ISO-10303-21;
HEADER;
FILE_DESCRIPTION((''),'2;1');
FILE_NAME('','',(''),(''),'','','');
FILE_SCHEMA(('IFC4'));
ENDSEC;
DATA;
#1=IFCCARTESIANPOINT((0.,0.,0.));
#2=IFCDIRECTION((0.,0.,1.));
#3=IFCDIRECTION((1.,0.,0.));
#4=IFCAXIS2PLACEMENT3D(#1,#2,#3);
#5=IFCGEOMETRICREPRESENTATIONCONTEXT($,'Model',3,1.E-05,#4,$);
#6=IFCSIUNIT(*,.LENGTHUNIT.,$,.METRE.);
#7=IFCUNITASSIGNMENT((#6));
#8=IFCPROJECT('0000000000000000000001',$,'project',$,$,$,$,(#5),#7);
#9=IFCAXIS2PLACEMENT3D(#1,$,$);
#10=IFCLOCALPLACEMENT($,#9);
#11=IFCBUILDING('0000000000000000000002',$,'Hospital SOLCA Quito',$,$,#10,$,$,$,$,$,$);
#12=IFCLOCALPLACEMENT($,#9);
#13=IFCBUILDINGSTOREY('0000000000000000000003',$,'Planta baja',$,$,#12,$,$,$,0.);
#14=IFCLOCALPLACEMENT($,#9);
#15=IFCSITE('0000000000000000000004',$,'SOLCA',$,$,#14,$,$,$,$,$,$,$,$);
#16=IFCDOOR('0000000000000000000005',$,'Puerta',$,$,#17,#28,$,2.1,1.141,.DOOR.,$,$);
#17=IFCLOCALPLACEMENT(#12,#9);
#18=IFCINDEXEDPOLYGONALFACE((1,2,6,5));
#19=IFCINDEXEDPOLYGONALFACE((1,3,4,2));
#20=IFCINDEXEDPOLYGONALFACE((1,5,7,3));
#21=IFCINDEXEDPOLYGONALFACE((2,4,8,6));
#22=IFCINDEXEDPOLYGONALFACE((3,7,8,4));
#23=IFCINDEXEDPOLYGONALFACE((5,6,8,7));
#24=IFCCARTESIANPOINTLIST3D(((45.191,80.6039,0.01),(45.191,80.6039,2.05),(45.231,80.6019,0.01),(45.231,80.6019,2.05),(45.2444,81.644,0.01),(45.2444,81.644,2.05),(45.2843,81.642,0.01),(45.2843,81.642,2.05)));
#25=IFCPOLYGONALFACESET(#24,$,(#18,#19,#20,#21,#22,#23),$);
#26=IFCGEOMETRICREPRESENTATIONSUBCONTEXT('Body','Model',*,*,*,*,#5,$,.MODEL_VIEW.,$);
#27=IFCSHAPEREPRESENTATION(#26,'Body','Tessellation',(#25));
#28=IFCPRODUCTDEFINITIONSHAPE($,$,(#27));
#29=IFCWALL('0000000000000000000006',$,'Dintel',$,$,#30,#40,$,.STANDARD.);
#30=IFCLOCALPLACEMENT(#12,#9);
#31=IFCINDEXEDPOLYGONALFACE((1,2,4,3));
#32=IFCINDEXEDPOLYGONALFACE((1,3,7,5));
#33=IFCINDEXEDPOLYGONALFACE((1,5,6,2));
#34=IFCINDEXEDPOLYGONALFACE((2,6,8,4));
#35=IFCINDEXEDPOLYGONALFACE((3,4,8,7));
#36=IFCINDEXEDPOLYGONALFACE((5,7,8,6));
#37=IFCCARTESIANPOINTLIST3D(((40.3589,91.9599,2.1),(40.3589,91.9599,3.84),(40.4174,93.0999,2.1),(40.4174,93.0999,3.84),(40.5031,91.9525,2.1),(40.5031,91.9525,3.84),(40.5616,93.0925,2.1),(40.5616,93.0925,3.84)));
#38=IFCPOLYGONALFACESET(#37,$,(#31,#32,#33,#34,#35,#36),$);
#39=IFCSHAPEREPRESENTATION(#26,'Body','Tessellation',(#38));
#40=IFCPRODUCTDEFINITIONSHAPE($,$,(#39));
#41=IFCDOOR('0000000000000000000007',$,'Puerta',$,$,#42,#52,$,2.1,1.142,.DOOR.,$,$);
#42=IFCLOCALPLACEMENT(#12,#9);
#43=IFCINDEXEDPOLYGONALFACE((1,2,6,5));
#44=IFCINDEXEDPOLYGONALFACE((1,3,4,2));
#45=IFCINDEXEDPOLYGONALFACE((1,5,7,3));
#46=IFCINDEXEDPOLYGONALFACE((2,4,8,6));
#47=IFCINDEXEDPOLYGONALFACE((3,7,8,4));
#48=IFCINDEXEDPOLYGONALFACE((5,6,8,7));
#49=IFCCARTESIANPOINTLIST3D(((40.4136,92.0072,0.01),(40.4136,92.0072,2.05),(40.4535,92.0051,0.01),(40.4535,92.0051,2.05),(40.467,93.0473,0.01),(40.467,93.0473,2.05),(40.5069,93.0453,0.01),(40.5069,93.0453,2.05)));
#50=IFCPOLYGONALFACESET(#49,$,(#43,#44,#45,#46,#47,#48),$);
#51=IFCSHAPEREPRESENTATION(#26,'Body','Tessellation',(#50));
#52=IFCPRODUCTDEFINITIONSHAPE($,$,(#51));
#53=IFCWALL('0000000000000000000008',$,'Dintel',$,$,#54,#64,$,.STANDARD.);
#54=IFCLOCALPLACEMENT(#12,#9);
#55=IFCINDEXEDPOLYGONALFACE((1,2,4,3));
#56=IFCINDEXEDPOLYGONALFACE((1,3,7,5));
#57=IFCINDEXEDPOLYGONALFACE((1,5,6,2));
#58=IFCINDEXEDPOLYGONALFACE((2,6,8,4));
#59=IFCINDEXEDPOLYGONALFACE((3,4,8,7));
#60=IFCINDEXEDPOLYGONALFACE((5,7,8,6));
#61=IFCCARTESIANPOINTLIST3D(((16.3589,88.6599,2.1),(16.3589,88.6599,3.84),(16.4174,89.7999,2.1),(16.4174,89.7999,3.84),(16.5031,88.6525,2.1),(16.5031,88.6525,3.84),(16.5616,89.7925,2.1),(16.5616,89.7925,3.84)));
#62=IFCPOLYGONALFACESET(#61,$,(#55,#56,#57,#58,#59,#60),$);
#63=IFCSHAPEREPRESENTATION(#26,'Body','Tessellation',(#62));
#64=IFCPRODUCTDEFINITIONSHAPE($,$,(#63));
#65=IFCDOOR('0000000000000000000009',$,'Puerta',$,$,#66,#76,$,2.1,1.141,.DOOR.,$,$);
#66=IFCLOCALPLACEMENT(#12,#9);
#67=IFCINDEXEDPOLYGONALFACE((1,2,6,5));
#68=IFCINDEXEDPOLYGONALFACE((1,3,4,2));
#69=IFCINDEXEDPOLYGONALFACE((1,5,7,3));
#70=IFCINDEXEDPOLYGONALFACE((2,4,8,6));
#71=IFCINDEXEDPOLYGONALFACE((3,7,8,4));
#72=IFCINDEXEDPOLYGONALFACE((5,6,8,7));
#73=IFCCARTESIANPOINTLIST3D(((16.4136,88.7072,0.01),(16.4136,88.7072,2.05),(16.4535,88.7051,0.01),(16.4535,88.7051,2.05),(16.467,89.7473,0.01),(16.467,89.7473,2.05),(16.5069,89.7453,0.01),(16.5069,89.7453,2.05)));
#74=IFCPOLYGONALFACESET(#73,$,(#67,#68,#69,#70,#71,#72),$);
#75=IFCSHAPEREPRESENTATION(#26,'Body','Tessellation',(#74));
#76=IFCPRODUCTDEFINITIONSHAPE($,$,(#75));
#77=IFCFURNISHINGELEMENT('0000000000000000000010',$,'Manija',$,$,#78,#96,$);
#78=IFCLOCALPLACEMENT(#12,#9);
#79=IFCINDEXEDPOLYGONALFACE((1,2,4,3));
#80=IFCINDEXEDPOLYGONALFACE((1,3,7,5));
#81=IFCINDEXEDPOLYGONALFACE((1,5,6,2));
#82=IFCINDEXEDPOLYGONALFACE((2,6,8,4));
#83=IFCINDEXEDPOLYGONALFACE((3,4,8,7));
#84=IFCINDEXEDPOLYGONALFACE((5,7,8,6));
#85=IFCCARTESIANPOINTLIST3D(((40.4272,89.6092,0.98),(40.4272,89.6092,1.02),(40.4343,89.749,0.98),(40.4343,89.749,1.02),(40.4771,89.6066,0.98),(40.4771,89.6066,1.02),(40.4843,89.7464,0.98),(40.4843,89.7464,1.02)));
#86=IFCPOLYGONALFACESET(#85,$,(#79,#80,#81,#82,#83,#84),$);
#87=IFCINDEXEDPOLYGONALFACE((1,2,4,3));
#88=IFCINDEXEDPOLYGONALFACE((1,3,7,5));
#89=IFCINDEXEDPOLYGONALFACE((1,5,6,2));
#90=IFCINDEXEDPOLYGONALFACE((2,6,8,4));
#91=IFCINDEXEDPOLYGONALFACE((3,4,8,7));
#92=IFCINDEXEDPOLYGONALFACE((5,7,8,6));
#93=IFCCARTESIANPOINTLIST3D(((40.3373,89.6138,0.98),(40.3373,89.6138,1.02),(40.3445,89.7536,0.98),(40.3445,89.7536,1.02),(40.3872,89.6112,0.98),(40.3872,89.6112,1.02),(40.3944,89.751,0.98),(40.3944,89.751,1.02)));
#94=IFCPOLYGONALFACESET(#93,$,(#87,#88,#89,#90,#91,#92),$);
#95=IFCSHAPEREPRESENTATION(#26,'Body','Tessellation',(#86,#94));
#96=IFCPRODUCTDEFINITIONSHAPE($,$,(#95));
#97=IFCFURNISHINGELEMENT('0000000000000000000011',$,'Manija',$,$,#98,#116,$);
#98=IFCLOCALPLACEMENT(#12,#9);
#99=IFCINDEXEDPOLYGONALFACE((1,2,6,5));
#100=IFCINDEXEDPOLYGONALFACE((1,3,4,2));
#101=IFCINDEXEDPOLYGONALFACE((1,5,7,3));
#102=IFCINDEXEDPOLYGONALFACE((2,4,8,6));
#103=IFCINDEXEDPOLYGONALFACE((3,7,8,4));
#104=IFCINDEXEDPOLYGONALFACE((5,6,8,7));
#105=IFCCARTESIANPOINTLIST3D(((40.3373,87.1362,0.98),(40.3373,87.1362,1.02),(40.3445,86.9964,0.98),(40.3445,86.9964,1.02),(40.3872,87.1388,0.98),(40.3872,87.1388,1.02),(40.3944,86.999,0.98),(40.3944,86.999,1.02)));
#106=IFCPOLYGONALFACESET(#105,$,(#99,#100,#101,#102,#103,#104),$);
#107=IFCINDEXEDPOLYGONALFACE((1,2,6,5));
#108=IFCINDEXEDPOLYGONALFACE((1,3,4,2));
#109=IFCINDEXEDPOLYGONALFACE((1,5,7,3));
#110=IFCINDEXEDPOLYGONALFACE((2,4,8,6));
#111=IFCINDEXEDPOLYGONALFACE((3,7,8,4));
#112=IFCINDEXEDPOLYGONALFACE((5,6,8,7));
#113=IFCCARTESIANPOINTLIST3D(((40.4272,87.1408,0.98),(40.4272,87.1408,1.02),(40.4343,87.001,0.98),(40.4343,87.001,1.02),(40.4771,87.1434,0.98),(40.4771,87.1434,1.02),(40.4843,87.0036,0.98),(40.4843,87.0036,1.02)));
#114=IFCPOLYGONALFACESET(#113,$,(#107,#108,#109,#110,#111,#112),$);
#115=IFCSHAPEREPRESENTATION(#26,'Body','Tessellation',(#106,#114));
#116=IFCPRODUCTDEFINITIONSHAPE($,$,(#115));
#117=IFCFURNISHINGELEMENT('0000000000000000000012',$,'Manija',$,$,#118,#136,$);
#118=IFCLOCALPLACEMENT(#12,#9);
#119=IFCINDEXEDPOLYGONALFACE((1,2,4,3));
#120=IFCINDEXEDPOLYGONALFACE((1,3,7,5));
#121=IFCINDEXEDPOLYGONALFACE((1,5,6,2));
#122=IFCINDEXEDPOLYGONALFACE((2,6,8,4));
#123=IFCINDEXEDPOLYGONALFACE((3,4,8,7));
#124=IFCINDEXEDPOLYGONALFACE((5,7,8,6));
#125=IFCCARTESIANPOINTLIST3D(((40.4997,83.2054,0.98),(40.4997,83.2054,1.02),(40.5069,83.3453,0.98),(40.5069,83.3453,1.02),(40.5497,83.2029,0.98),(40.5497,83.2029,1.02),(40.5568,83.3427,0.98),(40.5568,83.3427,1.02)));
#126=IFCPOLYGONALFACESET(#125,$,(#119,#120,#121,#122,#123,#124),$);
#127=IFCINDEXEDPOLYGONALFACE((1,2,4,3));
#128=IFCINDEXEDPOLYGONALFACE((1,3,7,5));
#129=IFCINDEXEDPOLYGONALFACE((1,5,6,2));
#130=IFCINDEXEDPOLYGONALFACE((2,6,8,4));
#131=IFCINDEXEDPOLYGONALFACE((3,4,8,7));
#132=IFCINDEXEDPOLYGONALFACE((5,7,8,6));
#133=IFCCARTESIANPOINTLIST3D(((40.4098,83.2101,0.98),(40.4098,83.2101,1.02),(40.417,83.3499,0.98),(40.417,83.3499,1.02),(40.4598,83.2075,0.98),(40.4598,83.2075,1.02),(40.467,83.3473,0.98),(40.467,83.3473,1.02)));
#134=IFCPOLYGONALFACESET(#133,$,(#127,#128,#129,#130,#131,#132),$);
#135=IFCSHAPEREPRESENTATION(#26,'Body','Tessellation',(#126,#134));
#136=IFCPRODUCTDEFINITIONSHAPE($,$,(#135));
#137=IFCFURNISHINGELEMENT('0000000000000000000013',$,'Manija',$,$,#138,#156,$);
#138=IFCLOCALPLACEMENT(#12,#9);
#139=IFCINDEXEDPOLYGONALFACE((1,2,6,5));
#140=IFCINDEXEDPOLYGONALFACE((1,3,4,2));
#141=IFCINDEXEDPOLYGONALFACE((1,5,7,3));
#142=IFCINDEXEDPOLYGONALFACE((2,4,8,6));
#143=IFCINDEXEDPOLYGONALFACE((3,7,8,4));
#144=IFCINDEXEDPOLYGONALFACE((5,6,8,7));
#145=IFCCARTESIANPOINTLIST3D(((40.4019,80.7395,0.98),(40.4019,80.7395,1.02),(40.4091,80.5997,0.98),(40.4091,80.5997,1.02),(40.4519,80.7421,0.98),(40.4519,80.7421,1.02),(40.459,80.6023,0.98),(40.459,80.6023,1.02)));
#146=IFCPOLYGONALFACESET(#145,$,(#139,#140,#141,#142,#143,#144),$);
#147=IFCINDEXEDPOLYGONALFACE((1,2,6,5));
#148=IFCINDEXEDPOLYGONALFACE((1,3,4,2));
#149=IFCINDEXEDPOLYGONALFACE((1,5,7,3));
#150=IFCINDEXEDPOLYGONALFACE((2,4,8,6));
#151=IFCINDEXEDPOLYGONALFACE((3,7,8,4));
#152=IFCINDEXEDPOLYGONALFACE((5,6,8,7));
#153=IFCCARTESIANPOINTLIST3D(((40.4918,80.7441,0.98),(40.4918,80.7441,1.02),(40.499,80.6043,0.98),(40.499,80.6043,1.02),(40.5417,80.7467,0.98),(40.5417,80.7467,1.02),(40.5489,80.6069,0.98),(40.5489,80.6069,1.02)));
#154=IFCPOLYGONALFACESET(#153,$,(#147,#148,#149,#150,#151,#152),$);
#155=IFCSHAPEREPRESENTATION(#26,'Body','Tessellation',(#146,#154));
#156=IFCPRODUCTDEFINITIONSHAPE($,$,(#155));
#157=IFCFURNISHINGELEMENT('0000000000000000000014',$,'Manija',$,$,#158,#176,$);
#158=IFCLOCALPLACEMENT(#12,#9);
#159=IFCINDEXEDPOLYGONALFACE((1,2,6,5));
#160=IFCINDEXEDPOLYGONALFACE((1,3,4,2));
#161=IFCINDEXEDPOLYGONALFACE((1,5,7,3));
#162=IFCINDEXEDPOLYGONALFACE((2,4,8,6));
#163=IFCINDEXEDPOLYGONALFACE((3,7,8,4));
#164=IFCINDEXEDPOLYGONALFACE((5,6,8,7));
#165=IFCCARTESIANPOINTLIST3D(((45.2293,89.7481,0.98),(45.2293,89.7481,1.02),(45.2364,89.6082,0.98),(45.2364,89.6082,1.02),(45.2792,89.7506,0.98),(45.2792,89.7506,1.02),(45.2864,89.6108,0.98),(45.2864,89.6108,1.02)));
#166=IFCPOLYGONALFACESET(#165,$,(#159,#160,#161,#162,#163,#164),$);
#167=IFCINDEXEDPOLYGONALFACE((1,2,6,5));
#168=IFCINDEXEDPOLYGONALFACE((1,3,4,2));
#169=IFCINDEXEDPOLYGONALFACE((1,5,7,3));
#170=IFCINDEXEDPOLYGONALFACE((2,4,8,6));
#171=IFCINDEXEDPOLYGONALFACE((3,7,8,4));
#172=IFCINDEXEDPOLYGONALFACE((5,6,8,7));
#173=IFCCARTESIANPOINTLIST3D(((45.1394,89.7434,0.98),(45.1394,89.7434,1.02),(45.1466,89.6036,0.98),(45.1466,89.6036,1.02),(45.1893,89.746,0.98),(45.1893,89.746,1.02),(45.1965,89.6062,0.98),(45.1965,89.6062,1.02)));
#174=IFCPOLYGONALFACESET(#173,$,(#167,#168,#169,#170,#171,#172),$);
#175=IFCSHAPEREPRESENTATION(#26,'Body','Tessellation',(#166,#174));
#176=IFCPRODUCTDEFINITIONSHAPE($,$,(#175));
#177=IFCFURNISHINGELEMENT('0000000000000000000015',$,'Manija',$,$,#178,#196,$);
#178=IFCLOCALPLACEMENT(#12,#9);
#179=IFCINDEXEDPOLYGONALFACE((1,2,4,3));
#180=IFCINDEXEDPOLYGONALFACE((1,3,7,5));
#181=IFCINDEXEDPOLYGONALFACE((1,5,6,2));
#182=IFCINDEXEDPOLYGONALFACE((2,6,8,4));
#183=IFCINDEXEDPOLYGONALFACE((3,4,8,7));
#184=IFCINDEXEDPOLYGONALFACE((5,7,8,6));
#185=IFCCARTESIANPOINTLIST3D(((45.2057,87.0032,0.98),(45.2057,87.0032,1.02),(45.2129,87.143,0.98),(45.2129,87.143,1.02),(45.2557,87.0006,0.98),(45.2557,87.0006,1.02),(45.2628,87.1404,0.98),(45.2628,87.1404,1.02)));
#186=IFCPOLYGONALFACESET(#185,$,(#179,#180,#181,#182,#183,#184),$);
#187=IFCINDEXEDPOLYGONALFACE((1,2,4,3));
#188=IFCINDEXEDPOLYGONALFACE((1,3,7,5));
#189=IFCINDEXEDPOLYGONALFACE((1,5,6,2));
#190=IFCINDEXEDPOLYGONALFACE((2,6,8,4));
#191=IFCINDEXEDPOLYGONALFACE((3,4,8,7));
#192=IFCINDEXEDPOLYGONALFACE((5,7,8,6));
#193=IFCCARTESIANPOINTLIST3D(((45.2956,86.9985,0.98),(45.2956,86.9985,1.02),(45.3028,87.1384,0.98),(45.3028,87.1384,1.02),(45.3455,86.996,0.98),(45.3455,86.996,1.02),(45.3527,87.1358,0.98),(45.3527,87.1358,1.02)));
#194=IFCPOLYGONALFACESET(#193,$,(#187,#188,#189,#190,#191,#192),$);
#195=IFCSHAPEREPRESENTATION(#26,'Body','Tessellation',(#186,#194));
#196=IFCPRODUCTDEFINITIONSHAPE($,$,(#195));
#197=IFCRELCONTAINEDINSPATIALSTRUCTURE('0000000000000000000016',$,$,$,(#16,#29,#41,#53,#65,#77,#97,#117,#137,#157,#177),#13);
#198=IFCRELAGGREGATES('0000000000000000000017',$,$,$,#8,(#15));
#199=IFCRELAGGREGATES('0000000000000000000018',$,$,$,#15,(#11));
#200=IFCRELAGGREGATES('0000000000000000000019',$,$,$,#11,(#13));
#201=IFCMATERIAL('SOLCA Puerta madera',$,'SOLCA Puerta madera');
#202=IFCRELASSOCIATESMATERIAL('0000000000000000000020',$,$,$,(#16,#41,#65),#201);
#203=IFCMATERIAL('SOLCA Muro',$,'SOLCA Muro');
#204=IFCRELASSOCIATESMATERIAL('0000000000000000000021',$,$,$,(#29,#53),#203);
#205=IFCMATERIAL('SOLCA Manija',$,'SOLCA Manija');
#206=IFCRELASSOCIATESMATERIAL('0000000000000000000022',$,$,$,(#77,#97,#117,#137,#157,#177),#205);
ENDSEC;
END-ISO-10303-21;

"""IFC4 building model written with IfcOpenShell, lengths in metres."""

from ifc_helpers import new_model, si_unit, frame, origin, origin_with_axes, place, context, subcontext, project, spatial, polyline, outline, extrude, material, element, save


model = new_model("IFC4")

# Units and contexts
model_context = context("Model", 3, precision=1e-05, world=origin_with_axes())
body_context = subcontext(model_context, "Body", "Model", "MODEL_VIEW")
ifc_project = project(units=[si_unit("LENGTHUNIT", "METRE")], contexts=[model_context])

# Site, building, storey
site_placement = place(None, origin())
site = spatial("IfcSite", under=ifc_project, at=site_placement, Name="SOLCA")
building_placement = place(None, origin())
building = spatial("IfcBuilding", under=site, at=building_placement, Name="Hospital SOLCA Quito")
storey_placement = place(None, origin())
storey = spatial("IfcBuildingStorey", under=building, at=storey_placement, Name="Planta baja", Elevation=0.0)

# Shared definitions
ifc_material_1 = material(Name="SOLCA Muro", Category="SOLCA Muro")

# Shared definitions
ifc_material_2 = material(Name="SOLCA Puerta madera", Category="SOLCA Puerta madera")

# Door
door_1_placement = place(storey_placement, origin_with_axes())
element("IfcDoor", 1, at=door_1_placement, inside=storey, material=ifc_material_2, Name="Puerta", OverallHeight=2.1, OverallWidth=1.141, PredefinedType="DOOR", context=body_context, shape_type="SweptSolid", body=[
    extrude(outline(polyline([(45.2444, 81.644), (45.191, 80.6039), (45.231, 80.6019), (45.2843, 81.642), (45.2444, 81.644)])), frame((0.0, 0.0, 0.01), z_axis=(0.0, 0.0, 1.0), x_axis=(1.0, 0.0, 0.0)), (0.0, 0.0, 1.0), 2.04),
])

# Wall
wall_1_placement = place(storey_placement, origin_with_axes())
element("IfcWall", 2, at=wall_1_placement, inside=storey, material=ifc_material_1, Name="Dintel", PredefinedType="STANDARD", context=body_context, shape_type="SweptSolid", body=[
    extrude(outline(polyline([(40.5031, 91.9525), (40.5616, 93.0925), (40.4174, 93.0999), (40.3589, 91.9599), (40.5031, 91.9525)])), frame((0.0, 0.0, 2.1), z_axis=(0.0, 0.0, 1.0), x_axis=(1.0, 0.0, 0.0)), (0.0, 0.0, 1.0), 1.74),
])

# Door
door_2_placement = place(storey_placement, origin_with_axes())
element("IfcDoor", 3, at=door_2_placement, inside=storey, material=ifc_material_2, Name="Puerta", OverallHeight=2.1, OverallWidth=1.142, PredefinedType="DOOR", context=body_context, shape_type="SweptSolid", body=[
    extrude(outline(polyline([(40.4535, 92.0051), (40.5069, 93.0453), (40.467, 93.0473), (40.4136, 92.0072), (40.4535, 92.0051)])), frame((0.0, 0.0, 0.01), z_axis=(0.0, 0.0, 1.0), x_axis=(1.0, 0.0, 0.0)), (0.0, 0.0, 1.0), 2.04),
])

# Wall
wall_2_placement = place(storey_placement, origin_with_axes())
element("IfcWall", 4, at=wall_2_placement, inside=storey, material=ifc_material_1, Name="Dintel", PredefinedType="STANDARD", context=body_context, shape_type="SweptSolid", body=[
    extrude(outline(polyline([(16.5031, 88.6525), (16.5616, 89.7925), (16.4174, 89.7999), (16.3589, 88.6599), (16.5031, 88.6525)])), frame((0.0, 0.0, 2.1), z_axis=(0.0, 0.0, 1.0), x_axis=(1.0, 0.0, 0.0)), (0.0, 0.0, 1.0), 1.74),
])

# Door
door_3_placement = place(storey_placement, origin_with_axes())
element("IfcDoor", 5, at=door_3_placement, inside=storey, material=ifc_material_2, Name="Puerta", OverallHeight=2.1, OverallWidth=1.141, PredefinedType="DOOR", context=body_context, shape_type="SweptSolid", body=[
    extrude(outline(polyline([(16.4535, 88.7051), (16.5069, 89.7453), (16.467, 89.7473), (16.4136, 88.7072), (16.4535, 88.7051)])), frame((0.0, 0.0, 0.01), z_axis=(0.0, 0.0, 1.0), x_axis=(1.0, 0.0, 0.0)), (0.0, 0.0, 1.0), 2.04),
])

# Furnishing elements
ifc_material_3 = material(Name="SOLCA Manija", Category="SOLCA Manija")
furnishing_1_placement = place(storey_placement, origin_with_axes())
element("IfcFurnishingElement", 6, at=furnishing_1_placement, inside=storey, material=ifc_material_3, Name="Manija", context=body_context, shape_type="SweptSolid", body=[
    extrude(outline(polyline([(40.4771, 89.6066), (40.4843, 89.7464), (40.4343, 89.749), (40.4272, 89.6092), (40.4771, 89.6066)])), frame((0.0, 0.0, 0.98), z_axis=(0.0, 0.0, 1.0), x_axis=(1.0, 0.0, 0.0)), (0.0, 0.0, 1.0), 0.04),
    extrude(outline(polyline([(40.3872, 89.6112), (40.3944, 89.751), (40.3445, 89.7536), (40.3373, 89.6138), (40.3872, 89.6112)])), frame((0.0, 0.0, 0.98), z_axis=(0.0, 0.0, 1.0), x_axis=(1.0, 0.0, 0.0)), (0.0, 0.0, 1.0), 0.04),
])
furnishing_2_placement = place(storey_placement, origin_with_axes())
element("IfcFurnishingElement", 7, at=furnishing_2_placement, inside=storey, material=ifc_material_3, Name="Manija", context=body_context, shape_type="SweptSolid", body=[
    extrude(outline(polyline([(40.3373, 87.1362), (40.3445, 86.9964), (40.3944, 86.999), (40.3872, 87.1388), (40.3373, 87.1362)])), frame((0.0, 0.0, 0.98), z_axis=(0.0, 0.0, 1.0), x_axis=(1.0, 0.0, 0.0)), (0.0, 0.0, 1.0), 0.04),
    extrude(outline(polyline([(40.4272, 87.1408), (40.4343, 87.001), (40.4843, 87.0036), (40.4771, 87.1434), (40.4272, 87.1408)])), frame((0.0, 0.0, 0.98), z_axis=(0.0, 0.0, 1.0), x_axis=(1.0, 0.0, 0.0)), (0.0, 0.0, 1.0), 0.04),
])
furnishing_3_placement = place(storey_placement, origin_with_axes())
element("IfcFurnishingElement", 8, at=furnishing_3_placement, inside=storey, material=ifc_material_3, Name="Manija", context=body_context, shape_type="SweptSolid", body=[
    extrude(outline(polyline([(40.5497, 83.2029), (40.5568, 83.3427), (40.5069, 83.3453), (40.4997, 83.2054), (40.5497, 83.2029)])), frame((0.0, 0.0, 0.98), z_axis=(0.0, 0.0, 1.0), x_axis=(1.0, 0.0, 0.0)), (0.0, 0.0, 1.0), 0.04),
    extrude(outline(polyline([(40.4598, 83.2075), (40.467, 83.3473), (40.417, 83.3499), (40.4098, 83.2101), (40.4598, 83.2075)])), frame((0.0, 0.0, 0.98), z_axis=(0.0, 0.0, 1.0), x_axis=(1.0, 0.0, 0.0)), (0.0, 0.0, 1.0), 0.04),
])
furnishing_4_placement = place(storey_placement, origin_with_axes())
element("IfcFurnishingElement", 9, at=furnishing_4_placement, inside=storey, material=ifc_material_3, Name="Manija", context=body_context, shape_type="SweptSolid", body=[
    extrude(outline(polyline([(40.4019, 80.7395), (40.4091, 80.5997), (40.459, 80.6023), (40.4519, 80.7421), (40.4019, 80.7395)])), frame((0.0, 0.0, 0.98), z_axis=(0.0, 0.0, 1.0), x_axis=(1.0, 0.0, 0.0)), (0.0, 0.0, 1.0), 0.04),
    extrude(outline(polyline([(40.4918, 80.7441), (40.499, 80.6043), (40.5489, 80.6069), (40.5417, 80.7467), (40.4918, 80.7441)])), frame((0.0, 0.0, 0.98), z_axis=(0.0, 0.0, 1.0), x_axis=(1.0, 0.0, 0.0)), (0.0, 0.0, 1.0), 0.04),
])
furnishing_5_placement = place(storey_placement, origin_with_axes())
element("IfcFurnishingElement", 10, at=furnishing_5_placement, inside=storey, material=ifc_material_3, Name="Manija", context=body_context, shape_type="SweptSolid", body=[
    extrude(outline(polyline([(45.2864, 89.6108), (45.2792, 89.7506), (45.2293, 89.7481), (45.2364, 89.6082), (45.2864, 89.6108)])), frame((0.0, 0.0, 0.98), z_axis=(0.0, 0.0, 1.0), x_axis=(1.0, 0.0, 0.0)), (0.0, 0.0, 1.0), 0.04),
    extrude(outline(polyline([(45.1965, 89.6062), (45.1893, 89.746), (45.1394, 89.7434), (45.1466, 89.6036), (45.1965, 89.6062)])), frame((0.0, 0.0, 0.98), z_axis=(0.0, 0.0, 1.0), x_axis=(1.0, 0.0, 0.0)), (0.0, 0.0, 1.0), 0.04),
])
furnishing_6_placement = place(storey_placement, origin_with_axes())
element("IfcFurnishingElement", 11, at=furnishing_6_placement, inside=storey, material=ifc_material_3, Name="Manija", context=body_context, shape_type="SweptSolid", body=[
    extrude(outline(polyline([(45.2129, 87.143), (45.2057, 87.0032), (45.2557, 87.0006), (45.2628, 87.1404), (45.2129, 87.143)])), frame((0.0, 0.0, 0.98), z_axis=(0.0, 0.0, 1.0), x_axis=(1.0, 0.0, 0.0)), (0.0, 0.0, 1.0), 0.04),
    extrude(outline(polyline([(45.3028, 87.1384), (45.2956, 86.9985), (45.3455, 86.996), (45.3527, 87.1358), (45.3028, 87.1384)])), frame((0.0, 0.0, 0.98), z_axis=(0.0, 0.0, 1.0), x_axis=(1.0, 0.0, 0.0)), (0.0, 0.0, 1.0), 0.04),
])

save(model, "model.ifc")
